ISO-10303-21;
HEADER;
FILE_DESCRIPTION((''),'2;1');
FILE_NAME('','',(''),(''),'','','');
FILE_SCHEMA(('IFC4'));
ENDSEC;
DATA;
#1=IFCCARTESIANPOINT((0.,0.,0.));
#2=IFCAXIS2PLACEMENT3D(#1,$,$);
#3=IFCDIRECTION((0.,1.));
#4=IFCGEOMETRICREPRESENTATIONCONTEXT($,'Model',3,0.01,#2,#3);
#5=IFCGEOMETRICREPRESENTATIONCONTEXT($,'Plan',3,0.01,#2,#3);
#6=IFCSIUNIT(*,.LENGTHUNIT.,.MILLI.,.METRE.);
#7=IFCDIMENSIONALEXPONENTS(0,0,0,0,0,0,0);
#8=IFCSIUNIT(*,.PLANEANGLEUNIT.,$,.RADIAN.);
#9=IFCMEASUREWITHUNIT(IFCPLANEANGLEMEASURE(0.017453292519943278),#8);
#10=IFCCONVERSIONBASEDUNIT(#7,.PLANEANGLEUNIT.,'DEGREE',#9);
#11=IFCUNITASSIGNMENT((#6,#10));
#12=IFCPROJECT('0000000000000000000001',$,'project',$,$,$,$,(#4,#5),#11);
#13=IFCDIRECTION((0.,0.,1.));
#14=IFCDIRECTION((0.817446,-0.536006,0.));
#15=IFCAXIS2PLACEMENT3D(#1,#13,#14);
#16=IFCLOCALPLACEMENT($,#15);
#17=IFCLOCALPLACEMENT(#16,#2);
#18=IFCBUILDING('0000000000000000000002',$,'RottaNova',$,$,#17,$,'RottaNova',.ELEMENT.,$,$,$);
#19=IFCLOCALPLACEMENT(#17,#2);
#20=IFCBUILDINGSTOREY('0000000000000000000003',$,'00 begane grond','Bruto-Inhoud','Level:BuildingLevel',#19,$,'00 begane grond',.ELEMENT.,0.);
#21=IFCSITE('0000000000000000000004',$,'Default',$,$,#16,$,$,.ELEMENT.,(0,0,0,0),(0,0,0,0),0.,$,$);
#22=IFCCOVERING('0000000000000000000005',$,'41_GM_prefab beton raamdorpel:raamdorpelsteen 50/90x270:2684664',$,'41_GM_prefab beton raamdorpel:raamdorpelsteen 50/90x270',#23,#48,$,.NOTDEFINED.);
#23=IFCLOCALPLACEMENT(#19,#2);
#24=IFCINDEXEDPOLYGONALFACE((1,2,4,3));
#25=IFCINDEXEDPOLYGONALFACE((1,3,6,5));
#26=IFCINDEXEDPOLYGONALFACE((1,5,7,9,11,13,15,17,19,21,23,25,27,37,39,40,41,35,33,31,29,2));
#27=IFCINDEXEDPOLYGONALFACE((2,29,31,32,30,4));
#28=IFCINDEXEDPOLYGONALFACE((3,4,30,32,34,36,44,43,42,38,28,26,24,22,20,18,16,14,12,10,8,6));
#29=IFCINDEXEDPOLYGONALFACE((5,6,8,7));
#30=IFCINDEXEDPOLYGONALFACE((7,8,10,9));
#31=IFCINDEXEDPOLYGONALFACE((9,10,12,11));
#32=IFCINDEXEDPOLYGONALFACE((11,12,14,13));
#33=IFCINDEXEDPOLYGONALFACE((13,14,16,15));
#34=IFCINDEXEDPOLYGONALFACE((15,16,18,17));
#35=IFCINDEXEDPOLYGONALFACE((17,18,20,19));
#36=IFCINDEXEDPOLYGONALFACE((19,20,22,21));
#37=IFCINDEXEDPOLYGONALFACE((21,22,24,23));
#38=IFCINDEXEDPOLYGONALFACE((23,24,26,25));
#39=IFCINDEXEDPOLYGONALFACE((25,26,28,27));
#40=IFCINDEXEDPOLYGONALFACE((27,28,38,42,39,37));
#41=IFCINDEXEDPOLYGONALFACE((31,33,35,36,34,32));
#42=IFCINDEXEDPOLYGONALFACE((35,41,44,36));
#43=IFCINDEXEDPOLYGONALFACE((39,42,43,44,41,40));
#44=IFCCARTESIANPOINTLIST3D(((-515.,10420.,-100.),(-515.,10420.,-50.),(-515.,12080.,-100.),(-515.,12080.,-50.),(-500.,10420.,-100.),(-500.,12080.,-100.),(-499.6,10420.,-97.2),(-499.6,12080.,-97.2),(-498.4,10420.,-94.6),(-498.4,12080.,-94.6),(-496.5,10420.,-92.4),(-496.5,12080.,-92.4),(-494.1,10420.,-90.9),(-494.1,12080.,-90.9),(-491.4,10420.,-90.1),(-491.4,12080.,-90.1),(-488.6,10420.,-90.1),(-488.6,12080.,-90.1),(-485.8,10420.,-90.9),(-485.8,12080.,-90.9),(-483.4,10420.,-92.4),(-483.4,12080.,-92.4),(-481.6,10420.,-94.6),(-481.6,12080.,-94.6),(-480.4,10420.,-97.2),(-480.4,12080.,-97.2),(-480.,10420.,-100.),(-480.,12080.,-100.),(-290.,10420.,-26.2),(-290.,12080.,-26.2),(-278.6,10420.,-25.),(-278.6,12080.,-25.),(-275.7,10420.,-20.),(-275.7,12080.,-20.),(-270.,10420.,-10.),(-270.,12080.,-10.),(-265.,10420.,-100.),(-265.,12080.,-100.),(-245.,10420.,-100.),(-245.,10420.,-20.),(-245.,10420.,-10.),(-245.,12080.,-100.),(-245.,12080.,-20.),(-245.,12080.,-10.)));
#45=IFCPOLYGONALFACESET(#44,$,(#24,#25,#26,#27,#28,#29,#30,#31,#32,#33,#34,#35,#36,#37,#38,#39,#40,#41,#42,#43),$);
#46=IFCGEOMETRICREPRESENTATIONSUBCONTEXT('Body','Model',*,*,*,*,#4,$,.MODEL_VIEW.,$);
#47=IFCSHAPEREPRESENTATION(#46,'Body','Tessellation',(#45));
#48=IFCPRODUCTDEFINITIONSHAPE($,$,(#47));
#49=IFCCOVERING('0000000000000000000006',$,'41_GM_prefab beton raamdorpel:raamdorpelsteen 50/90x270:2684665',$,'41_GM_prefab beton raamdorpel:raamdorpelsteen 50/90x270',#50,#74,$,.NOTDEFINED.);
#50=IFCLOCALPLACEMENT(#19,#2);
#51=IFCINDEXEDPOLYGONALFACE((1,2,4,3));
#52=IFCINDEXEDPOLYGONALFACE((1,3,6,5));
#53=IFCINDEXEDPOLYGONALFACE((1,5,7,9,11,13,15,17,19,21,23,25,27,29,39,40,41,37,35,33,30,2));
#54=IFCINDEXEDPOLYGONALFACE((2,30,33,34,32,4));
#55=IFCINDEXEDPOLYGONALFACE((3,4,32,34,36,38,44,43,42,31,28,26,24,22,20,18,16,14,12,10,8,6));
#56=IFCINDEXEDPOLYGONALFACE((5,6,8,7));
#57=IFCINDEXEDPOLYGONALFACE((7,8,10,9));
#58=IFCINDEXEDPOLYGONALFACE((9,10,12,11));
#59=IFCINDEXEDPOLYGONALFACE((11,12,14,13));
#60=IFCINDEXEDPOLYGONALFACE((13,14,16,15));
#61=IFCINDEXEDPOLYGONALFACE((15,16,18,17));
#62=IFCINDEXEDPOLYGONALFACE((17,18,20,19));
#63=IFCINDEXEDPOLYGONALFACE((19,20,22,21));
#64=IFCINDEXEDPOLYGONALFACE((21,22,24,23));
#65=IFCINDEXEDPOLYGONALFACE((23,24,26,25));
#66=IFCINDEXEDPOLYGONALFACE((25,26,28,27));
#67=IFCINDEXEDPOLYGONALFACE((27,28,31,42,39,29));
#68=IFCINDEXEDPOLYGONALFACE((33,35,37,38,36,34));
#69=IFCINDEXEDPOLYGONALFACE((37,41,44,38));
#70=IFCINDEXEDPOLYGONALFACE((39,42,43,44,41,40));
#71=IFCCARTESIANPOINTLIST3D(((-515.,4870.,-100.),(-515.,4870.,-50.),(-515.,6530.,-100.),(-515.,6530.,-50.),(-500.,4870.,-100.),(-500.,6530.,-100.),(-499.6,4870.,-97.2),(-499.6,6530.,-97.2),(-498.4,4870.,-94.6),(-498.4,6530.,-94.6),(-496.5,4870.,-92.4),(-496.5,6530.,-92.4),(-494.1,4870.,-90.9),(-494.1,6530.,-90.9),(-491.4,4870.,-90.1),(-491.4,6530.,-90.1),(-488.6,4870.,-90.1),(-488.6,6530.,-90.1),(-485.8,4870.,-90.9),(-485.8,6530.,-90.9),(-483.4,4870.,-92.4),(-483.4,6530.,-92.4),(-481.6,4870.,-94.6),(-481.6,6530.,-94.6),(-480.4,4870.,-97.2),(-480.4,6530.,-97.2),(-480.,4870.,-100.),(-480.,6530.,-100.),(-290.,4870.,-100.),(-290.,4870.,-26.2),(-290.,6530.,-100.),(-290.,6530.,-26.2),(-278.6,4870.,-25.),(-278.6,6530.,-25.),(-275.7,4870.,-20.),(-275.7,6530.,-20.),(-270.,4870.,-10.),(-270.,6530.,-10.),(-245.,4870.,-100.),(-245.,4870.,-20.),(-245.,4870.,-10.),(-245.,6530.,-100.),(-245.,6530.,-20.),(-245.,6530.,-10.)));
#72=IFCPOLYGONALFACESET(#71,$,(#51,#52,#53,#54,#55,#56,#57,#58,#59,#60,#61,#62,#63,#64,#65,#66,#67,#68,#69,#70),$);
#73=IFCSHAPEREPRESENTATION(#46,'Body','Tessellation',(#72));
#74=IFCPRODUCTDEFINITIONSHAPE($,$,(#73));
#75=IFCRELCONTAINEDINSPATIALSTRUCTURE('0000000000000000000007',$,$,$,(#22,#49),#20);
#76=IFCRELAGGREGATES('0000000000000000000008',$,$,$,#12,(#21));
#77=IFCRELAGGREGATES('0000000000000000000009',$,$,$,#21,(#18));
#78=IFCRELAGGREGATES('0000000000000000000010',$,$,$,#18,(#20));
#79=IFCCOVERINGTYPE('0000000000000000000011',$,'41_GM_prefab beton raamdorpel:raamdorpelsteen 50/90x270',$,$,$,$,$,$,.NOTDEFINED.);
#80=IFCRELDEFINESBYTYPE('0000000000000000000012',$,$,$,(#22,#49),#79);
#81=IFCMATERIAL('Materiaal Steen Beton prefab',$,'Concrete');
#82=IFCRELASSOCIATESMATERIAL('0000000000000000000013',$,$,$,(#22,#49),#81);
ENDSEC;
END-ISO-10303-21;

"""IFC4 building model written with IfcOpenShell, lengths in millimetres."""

from ifc_helpers import new_model, entity, si_unit, converted_unit, direction, frame, origin, place, context, subcontext, project, spatial, line, arc, indexed_curve, outline, extrude, material, type_object, element, save


model = new_model("IFC4")

# Units and contexts
model_context = context("Model", 3, precision=0.01, world=origin(), true_north=direction((0.0, 1.0)))
plan_context = context("Plan", 3, precision=0.01, world=origin(), true_north=direction((0.0, 1.0)))
body_context = subcontext(model_context, "Body", "Model", "MODEL_VIEW")
ifc_project = project(units=[si_unit("LENGTHUNIT", "METRE", prefix="MILLI"), converted_unit("PLANEANGLEUNIT", "DEGREE", entity("IfcPlaneAngleMeasure", 0.017453292519943278), si_unit("PLANEANGLEUNIT", "RADIAN"), dimensions=[0, 0, 0, 0, 0, 0, 0])], contexts=[model_context, plan_context])

# Site, building, storey
site_placement = place(None, frame((0.0, 0.0, 0.0), z_axis=(0.0, 0.0, 1.0), x_axis=(0.817446, -0.536006, 0.0)))
site = spatial("IfcSite", under=ifc_project, at=site_placement, Name="Default", CompositionType="ELEMENT", RefLatitude=(0, 0, 0, 0), RefLongitude=(0, 0, 0, 0), RefElevation=0.0)
building_placement = place(site_placement, origin())
building = spatial("IfcBuilding", under=site, at=building_placement, Name="RottaNova", LongName="RottaNova", CompositionType="ELEMENT")
storey_placement = place(building_placement, origin())
storey = spatial("IfcBuildingStorey", under=building, at=storey_placement, Name="00 begane grond", Description="Bruto-Inhoud", ObjectType="Level:BuildingLevel", LongName="00 begane grond", CompositionType="ELEMENT", Elevation=0.0)

# Shared definitions
ifc_material_1 = material(Name="Materiaal Steen Beton prefab", Category="Concrete")

# Coverings
covering_type_1 = type_object("IfcCoveringType", Name="41_GM_prefab beton raamdorpel:raamdorpelsteen 50/90x270", PredefinedType="NOTDEFINED")
covering_1_placement = place(storey_placement, origin())
element("IfcCovering", 1, at=covering_1_placement, inside=storey, type_object=covering_type_1, material=ifc_material_1, Name="41_GM_prefab beton raamdorpel:raamdorpelsteen 50/90x270:2684664", ObjectType="41_GM_prefab beton raamdorpel:raamdorpelsteen 50/90x270", PredefinedType="NOTDEFINED", context=body_context, shape_type="SweptSolid", body=[
    extrude(outline(indexed_curve([(73.7, -45.1), (98.7, -45.1), (98.7, -35.1), (98.7, 44.9), (78.7, 44.9), (-136.3, 44.9), (-146.3, 34.9), (-156.3, 44.9), (-171.3, 44.9), (-171.3, -5.1), (53.7, -28.9), (65.1, -30.1), (67.9, -35.1)], segments=[line(1, 2, 3, 4, 5, 6), arc(6, 7, 8), line(8, 9, 10, 11, 12, 13, 1)], self_intersect=False)), frame((-343.7, 10420.0, -55.1), z_axis=(0.0, 1.0, 0.0), x_axis=(1.0, 0.0, 0.0)), (0.0, 0.0, 1.0), 1660.0),
])
covering_2_placement = place(storey_placement, origin())
element("IfcCovering", 2, at=covering_2_placement, inside=storey, type_object=covering_type_1, material=ifc_material_1, Name="41_GM_prefab beton raamdorpel:raamdorpelsteen 50/90x270:2684665", ObjectType="41_GM_prefab beton raamdorpel:raamdorpelsteen 50/90x270", PredefinedType="NOTDEFINED", context=body_context, shape_type="SweptSolid", body=[
    extrude(outline(indexed_curve([(75.8, -45.1), (100.8, -45.1), (100.8, -35.1), (100.8, 44.9), (55.8, 44.9), (-134.2, 44.9), (-144.2, 34.9), (-154.2, 44.9), (-169.2, 44.9), (-169.2, -5.1), (55.8, -28.9), (67.1, -30.1), (70.0, -35.1)], segments=[line(1, 2, 3, 4, 5, 6), arc(6, 7, 8), line(8, 9, 10, 11, 12, 13, 1)], self_intersect=False)), frame((-345.8, 4870.0, -55.1), z_axis=(0.0, 1.0, 0.0), x_axis=(1.0, 0.0, 0.0)), (0.0, 0.0, 1.0), 1660.0),
])

save(model, "model.ifc")
